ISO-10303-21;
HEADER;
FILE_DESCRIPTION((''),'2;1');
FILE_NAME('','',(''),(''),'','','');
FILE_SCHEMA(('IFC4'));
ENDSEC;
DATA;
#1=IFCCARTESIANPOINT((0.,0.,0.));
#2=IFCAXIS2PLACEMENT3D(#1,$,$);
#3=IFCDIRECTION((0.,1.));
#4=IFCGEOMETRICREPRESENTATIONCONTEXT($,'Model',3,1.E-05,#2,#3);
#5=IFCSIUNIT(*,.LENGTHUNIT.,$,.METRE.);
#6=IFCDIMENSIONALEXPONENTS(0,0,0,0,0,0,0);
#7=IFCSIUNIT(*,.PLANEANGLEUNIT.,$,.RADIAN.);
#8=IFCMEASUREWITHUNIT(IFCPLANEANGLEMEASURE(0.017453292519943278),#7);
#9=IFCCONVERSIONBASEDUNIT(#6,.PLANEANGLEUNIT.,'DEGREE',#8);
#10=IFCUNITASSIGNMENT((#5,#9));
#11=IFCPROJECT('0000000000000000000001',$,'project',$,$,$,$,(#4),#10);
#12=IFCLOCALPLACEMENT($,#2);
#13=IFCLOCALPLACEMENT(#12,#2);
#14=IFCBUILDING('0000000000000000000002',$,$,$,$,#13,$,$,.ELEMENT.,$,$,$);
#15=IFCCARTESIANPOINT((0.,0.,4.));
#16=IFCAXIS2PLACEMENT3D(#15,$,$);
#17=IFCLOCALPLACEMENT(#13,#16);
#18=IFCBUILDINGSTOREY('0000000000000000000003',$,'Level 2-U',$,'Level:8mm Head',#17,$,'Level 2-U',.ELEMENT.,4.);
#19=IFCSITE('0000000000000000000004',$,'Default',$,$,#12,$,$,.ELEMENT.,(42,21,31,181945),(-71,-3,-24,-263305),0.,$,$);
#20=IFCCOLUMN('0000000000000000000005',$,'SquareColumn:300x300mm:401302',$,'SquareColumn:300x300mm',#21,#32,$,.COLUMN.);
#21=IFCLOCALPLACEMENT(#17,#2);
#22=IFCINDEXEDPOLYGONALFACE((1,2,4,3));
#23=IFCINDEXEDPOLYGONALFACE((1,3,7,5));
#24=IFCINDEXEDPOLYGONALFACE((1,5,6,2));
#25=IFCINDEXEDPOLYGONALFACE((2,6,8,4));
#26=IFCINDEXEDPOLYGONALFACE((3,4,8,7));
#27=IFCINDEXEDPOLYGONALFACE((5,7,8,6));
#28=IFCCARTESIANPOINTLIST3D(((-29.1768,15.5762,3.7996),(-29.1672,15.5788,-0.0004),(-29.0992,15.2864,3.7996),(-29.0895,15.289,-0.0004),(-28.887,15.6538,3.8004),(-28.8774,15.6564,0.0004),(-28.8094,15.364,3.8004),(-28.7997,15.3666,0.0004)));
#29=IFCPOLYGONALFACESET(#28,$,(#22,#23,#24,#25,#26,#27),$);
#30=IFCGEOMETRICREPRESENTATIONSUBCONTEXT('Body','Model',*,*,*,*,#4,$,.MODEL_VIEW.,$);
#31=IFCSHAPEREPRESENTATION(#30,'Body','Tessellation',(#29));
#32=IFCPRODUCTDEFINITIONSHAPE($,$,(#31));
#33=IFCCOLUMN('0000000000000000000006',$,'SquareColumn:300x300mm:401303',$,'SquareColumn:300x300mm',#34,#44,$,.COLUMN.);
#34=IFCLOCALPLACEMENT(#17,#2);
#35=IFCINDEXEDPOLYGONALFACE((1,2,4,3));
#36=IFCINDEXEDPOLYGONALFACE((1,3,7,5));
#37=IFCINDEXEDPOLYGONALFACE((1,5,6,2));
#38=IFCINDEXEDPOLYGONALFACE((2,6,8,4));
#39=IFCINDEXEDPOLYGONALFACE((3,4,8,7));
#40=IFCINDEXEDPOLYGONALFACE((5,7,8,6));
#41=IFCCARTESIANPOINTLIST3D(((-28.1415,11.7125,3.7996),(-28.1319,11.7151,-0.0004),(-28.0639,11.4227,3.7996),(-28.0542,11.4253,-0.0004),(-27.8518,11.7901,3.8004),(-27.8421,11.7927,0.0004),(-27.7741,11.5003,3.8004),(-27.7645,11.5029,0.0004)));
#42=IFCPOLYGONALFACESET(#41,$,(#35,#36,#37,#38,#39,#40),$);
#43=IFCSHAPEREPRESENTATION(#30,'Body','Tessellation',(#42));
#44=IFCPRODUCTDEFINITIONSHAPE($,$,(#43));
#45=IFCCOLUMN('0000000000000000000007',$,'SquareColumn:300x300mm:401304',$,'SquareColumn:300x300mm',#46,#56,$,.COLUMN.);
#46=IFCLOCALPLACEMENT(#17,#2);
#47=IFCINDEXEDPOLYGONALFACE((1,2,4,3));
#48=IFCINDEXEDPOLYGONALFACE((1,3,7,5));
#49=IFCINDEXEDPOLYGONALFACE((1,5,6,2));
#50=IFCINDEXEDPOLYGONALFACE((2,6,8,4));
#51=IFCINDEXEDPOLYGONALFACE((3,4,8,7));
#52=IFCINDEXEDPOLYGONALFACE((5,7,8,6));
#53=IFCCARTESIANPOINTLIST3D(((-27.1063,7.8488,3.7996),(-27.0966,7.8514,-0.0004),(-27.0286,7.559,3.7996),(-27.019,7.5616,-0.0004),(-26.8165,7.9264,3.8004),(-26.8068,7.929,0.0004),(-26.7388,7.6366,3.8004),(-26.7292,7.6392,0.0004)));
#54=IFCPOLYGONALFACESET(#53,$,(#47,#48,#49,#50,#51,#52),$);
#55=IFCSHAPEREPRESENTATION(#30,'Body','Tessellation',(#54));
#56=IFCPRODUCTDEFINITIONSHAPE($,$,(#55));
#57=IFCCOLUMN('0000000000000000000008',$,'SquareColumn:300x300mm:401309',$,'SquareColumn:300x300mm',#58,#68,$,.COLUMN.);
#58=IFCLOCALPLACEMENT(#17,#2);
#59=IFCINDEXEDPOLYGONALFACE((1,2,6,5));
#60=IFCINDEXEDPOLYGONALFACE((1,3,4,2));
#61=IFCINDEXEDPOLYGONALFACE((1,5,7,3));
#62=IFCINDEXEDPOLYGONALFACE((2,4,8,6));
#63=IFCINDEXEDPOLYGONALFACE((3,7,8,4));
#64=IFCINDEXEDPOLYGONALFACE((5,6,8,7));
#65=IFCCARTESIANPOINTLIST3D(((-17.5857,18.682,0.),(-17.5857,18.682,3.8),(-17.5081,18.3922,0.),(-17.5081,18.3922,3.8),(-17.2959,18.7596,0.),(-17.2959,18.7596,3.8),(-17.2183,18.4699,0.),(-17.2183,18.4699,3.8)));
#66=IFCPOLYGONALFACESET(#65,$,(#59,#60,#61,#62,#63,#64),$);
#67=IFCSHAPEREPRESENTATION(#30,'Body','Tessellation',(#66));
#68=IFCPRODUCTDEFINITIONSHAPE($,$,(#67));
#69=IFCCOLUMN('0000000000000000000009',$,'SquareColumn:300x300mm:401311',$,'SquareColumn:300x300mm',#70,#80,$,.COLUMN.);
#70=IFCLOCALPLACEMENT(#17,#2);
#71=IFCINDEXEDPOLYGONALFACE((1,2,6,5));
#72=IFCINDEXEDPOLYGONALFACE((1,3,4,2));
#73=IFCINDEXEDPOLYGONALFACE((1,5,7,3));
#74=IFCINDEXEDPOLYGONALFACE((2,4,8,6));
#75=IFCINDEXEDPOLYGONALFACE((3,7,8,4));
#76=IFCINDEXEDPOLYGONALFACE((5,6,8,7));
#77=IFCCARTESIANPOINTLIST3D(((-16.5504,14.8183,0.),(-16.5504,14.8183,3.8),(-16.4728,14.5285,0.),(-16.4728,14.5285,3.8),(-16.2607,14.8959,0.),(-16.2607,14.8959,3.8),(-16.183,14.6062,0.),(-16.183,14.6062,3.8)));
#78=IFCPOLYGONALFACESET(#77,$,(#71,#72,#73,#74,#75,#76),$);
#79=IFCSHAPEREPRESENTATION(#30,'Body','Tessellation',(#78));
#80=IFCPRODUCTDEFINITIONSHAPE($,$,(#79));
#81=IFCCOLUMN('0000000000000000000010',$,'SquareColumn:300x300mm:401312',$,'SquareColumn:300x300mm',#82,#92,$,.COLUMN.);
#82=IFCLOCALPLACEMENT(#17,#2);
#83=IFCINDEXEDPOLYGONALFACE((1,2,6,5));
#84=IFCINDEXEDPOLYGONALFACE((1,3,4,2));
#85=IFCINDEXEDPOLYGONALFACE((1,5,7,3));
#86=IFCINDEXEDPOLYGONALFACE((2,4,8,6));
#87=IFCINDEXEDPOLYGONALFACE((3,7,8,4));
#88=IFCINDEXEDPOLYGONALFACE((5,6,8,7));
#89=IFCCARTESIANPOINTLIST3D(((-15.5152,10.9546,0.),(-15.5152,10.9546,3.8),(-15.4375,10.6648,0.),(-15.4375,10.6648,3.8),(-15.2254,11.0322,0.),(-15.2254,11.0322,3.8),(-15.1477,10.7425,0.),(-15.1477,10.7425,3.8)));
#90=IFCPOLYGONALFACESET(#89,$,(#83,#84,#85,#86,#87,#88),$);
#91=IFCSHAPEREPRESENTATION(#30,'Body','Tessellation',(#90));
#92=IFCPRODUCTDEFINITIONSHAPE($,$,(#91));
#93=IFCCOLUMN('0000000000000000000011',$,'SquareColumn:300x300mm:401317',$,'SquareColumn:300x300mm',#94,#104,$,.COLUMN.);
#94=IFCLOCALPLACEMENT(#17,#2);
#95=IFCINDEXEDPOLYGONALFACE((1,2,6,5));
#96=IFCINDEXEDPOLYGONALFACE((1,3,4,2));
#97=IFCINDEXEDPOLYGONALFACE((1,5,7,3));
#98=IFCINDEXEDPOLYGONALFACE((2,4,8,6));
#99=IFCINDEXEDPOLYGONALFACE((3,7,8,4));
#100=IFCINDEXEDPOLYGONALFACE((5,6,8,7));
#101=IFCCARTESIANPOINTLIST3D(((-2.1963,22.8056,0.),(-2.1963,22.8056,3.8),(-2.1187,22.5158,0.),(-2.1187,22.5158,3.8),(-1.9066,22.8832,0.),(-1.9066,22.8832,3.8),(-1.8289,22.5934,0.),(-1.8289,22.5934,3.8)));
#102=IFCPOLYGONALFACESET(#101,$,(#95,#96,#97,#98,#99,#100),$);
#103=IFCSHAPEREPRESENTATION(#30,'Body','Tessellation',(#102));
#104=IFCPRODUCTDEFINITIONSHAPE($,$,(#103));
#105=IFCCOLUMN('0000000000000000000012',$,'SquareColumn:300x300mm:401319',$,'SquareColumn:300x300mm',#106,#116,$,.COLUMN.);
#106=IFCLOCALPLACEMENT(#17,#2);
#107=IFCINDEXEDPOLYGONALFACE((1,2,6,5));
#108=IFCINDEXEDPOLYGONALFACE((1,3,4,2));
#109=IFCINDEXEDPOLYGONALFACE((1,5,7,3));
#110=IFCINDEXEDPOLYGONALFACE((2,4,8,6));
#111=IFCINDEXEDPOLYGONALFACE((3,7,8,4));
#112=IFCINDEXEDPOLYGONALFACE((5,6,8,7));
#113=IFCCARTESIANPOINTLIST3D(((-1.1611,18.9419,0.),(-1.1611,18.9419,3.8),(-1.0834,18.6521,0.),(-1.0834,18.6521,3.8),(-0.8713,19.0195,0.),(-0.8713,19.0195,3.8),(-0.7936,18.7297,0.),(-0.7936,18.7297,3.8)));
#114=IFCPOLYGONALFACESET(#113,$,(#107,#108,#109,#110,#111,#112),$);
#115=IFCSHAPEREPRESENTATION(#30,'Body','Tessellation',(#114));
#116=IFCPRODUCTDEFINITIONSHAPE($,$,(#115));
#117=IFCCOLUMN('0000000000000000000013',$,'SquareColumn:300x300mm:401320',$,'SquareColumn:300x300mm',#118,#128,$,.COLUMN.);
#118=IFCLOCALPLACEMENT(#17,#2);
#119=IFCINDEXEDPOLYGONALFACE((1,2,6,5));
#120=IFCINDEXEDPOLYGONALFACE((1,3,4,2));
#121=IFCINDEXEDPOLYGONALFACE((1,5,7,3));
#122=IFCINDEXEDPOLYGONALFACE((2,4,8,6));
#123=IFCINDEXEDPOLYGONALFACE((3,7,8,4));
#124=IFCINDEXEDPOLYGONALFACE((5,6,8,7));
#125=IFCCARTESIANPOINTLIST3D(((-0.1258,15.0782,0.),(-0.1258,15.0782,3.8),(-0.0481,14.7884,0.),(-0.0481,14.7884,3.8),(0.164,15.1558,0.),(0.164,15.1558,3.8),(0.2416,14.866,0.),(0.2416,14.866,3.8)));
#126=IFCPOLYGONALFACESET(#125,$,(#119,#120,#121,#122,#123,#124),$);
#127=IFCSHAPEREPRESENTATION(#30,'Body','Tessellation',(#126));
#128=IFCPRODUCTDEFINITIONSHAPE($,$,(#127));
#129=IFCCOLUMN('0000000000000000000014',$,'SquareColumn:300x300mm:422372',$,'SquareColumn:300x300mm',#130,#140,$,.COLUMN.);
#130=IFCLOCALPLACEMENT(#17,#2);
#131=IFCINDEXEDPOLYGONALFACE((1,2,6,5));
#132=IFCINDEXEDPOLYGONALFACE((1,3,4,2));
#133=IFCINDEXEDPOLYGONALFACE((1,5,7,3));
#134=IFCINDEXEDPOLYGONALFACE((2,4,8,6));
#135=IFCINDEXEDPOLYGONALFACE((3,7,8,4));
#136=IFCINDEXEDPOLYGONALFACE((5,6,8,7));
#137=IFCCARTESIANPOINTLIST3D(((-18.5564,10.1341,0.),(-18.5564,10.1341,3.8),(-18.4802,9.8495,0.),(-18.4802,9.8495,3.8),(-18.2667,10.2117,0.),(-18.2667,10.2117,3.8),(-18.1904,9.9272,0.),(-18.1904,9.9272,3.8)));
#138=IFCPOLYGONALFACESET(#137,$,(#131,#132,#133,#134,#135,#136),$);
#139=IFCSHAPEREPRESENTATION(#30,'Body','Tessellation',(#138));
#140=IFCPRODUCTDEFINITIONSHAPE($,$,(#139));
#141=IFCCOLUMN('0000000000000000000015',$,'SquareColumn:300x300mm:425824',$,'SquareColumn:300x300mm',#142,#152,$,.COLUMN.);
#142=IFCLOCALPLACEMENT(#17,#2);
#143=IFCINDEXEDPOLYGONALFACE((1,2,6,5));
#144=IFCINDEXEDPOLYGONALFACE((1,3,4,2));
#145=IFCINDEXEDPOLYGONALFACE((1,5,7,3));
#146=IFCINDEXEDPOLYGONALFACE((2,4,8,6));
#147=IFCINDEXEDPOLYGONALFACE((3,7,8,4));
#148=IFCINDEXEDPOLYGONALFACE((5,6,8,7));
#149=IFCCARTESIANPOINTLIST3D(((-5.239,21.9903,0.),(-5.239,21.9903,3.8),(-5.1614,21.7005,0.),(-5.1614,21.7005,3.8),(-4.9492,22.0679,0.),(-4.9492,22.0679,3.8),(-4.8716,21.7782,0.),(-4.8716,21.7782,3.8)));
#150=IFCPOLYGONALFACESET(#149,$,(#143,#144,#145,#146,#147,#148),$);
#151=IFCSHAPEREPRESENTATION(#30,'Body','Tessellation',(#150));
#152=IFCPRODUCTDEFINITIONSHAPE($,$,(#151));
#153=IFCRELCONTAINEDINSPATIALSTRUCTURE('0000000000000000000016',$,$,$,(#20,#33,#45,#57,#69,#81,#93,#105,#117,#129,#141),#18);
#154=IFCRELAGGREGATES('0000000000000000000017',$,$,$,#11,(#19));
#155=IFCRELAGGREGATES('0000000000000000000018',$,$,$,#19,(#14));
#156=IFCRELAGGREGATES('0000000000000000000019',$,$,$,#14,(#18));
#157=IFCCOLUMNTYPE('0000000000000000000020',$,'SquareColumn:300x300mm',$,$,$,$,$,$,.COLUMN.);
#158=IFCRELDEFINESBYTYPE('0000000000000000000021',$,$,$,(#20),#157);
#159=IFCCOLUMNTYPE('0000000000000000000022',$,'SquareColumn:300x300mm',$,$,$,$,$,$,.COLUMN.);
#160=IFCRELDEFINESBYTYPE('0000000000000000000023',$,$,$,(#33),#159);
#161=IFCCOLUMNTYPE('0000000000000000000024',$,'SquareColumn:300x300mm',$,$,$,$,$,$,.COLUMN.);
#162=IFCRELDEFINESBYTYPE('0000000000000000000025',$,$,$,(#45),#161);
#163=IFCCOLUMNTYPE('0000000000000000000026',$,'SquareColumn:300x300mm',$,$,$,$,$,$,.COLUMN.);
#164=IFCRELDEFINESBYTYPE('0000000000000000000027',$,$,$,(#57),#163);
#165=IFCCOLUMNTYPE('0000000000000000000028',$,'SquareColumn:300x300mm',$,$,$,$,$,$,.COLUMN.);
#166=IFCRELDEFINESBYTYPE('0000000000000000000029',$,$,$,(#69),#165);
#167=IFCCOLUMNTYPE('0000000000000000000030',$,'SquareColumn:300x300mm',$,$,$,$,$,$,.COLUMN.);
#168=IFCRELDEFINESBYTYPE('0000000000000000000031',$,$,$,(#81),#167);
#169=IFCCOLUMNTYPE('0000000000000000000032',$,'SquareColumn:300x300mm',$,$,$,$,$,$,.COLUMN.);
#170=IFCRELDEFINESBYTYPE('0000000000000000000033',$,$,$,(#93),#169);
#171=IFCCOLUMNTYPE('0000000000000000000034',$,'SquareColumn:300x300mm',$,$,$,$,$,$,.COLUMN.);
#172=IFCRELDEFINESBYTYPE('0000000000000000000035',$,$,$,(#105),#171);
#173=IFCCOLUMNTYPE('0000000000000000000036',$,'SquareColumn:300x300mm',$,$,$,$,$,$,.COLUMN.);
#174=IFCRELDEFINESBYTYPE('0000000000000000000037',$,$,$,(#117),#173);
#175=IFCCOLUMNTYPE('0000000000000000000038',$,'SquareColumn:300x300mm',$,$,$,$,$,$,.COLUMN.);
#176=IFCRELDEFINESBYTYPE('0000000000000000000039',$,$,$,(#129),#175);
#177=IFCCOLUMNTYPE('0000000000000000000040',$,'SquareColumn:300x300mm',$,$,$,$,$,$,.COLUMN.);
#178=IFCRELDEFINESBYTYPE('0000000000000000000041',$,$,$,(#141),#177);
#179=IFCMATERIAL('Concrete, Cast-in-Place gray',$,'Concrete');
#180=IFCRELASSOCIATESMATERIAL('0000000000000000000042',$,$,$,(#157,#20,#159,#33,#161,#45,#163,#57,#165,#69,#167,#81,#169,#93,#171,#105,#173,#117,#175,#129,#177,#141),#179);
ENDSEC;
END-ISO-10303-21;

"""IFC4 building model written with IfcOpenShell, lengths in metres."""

from ifc_helpers import new_model, entity, si_unit, converted_unit, direction, frame, origin, place, context, subcontext, project, spatial, indexed_curve, outline, extrude, source, transform, mapped, material, type_object, type_shapes, element, save


model = new_model("IFC4")

# Units and contexts
model_context = context("Model", 3, precision=1e-05, world=origin(), true_north=direction((0.0, 1.0)))
body_context = subcontext(model_context, "Body", "Model", "MODEL_VIEW")
ifc_project = project(units=[si_unit("LENGTHUNIT", "METRE"), converted_unit("PLANEANGLEUNIT", "DEGREE", entity("IfcPlaneAngleMeasure", 0.017453292519943278), si_unit("PLANEANGLEUNIT", "RADIAN"), dimensions=[0, 0, 0, 0, 0, 0, 0])], contexts=[model_context])

# Site, building, storey
site_placement = place(None, origin())
site = spatial("IfcSite", under=ifc_project, at=site_placement, Name="Default", CompositionType="ELEMENT", RefLatitude=(42, 21, 31, 181945), RefLongitude=(-71, -3, -24, -263305), RefElevation=0.0)
building_placement = place(site_placement, origin())
building = spatial("IfcBuilding", under=site, at=building_placement, CompositionType="ELEMENT")
storey_placement = place(building_placement, frame((0.0, 0.0, 4.0)))
storey = spatial("IfcBuildingStorey", under=building, at=storey_placement, Name="Level 2-U", ObjectType="Level:8mm Head", LongName="Level 2-U", CompositionType="ELEMENT", Elevation=4.0)

# Columns
ifc_material_1 = material(Name="Concrete, Cast-in-Place gray", Category="Concrete")
column_type_1 = type_object("IfcColumnType", Name="SquareColumn:300x300mm", PredefinedType="COLUMN", material=ifc_material_1)
shared_shape_1 = source(origin(), body_context, "Body", "SweptSolid", [
    extrude(outline(indexed_curve([(-0.15, -0.15), (0.15, -0.15), (0.15, 0.15), (-0.15, 0.15), (-0.15, -0.15)], self_intersect=False)), frame((-28.9835, 15.4727, 4.0), z_axis=(-0.002542, -0.000681, 0.999997), x_axis=(-0.258819, 0.965926, 0.0)), (0.0, 0.0, 1.0), 3.8),
])
type_shapes(column_type_1, [shared_shape_1])
column_1_placement = place(storey_placement, frame((0.0, 0.0, -4.0)))
element("IfcColumn", 1, at=column_1_placement, inside=storey, type_object=column_type_1, material=ifc_material_1, Name="SquareColumn:300x300mm:401302", ObjectType="SquareColumn:300x300mm", PredefinedType="COLUMN", context=body_context, shape_type="MappedRepresentation", body=[
    mapped(shared_shape_1, transform((0.0, 0.0, 0.0), scale=1.0)),
])
column_type_2 = type_object("IfcColumnType", Name="SquareColumn:300x300mm", PredefinedType="COLUMN", material=ifc_material_1)
shared_shape_2 = source(origin(), body_context, "Body", "SweptSolid", [
    extrude(outline(indexed_curve([(-0.15, -0.15), (0.15, -0.15), (0.15, 0.15), (-0.15, 0.15), (-0.15, -0.15)], self_intersect=False)), frame((-27.9482, 11.609, 4.0), z_axis=(-0.002542, -0.000681, 0.999997), x_axis=(-0.258819, 0.965926, 0.0)), (0.0, 0.0, 1.0), 3.8),
])
type_shapes(column_type_2, [shared_shape_2])
column_2_placement = place(storey_placement, frame((0.0, 0.0, -4.0)))
element("IfcColumn", 2, at=column_2_placement, inside=storey, type_object=column_type_2, material=ifc_material_1, Name="SquareColumn:300x300mm:401303", ObjectType="SquareColumn:300x300mm", PredefinedType="COLUMN", context=body_context, shape_type="MappedRepresentation", body=[
    mapped(shared_shape_2, transform((0.0, 0.0, 0.0), scale=1.0)),
])
column_type_3 = type_object("IfcColumnType", Name="SquareColumn:300x300mm", PredefinedType="COLUMN", material=ifc_material_1)
shared_shape_3 = source(origin(), body_context, "Body", "SweptSolid", [
    extrude(outline(indexed_curve([(-0.15, -0.15), (0.15, -0.15), (0.15, 0.15), (-0.15, 0.15), (-0.15, -0.15)], self_intersect=False)), frame((-26.9129, 7.7453, 4.0), z_axis=(-0.002542, -0.000681, 0.999997), x_axis=(-0.258819, 0.965926, 0.0)), (0.0, 0.0, 1.0), 3.8),
])
type_shapes(column_type_3, [shared_shape_3])
column_3_placement = place(storey_placement, frame((0.0, 0.0, -4.0)))
element("IfcColumn", 3, at=column_3_placement, inside=storey, type_object=column_type_3, material=ifc_material_1, Name="SquareColumn:300x300mm:401304", ObjectType="SquareColumn:300x300mm", PredefinedType="COLUMN", context=body_context, shape_type="MappedRepresentation", body=[
    mapped(shared_shape_3, transform((0.0, 0.0, 0.0), scale=1.0)),
])
column_type_4 = type_object("IfcColumnType", Name="SquareColumn:300x300mm", PredefinedType="COLUMN", material=ifc_material_1)
shared_shape_4 = source(origin(), body_context, "Body", "SweptSolid", [
    extrude(outline(indexed_curve([(-0.15, -0.15), (0.15, -0.15), (0.15, 0.15), (-0.15, 0.15), (-0.15, -0.15)], self_intersect=False)), frame((-17.402, 18.5759, 4.0), z_axis=(0.0, 0.0, 1.0), x_axis=(-0.258819, 0.965926, 0.0)), (0.0, 0.0, 1.0), 3.8),
])
type_shapes(column_type_4, [shared_shape_4])
column_4_placement = place(storey_placement, frame((0.0, 0.0, -4.0)))
element("IfcColumn", 4, at=column_4_placement, inside=storey, type_object=column_type_4, material=ifc_material_1, Name="SquareColumn:300x300mm:401309", ObjectType="SquareColumn:300x300mm", PredefinedType="COLUMN", context=body_context, shape_type="MappedRepresentation", body=[
    mapped(shared_shape_4, transform((0.0, 0.0, 0.0), scale=1.0)),
])
column_type_5 = type_object("IfcColumnType", Name="SquareColumn:300x300mm", PredefinedType="COLUMN", material=ifc_material_1)
shared_shape_5 = source(origin(), body_context, "Body", "SweptSolid", [
    extrude(outline(indexed_curve([(-0.15, -0.15), (0.15, -0.15), (0.15, 0.15), (-0.15, 0.15), (-0.15, -0.15)], self_intersect=False)), frame((-16.3667, 14.7122, 4.0), z_axis=(0.0, 0.0, 1.0), x_axis=(-0.258819, 0.965926, 0.0)), (0.0, 0.0, 1.0), 3.8),
])
type_shapes(column_type_5, [shared_shape_5])
column_5_placement = place(storey_placement, frame((0.0, 0.0, -4.0)))
element("IfcColumn", 5, at=column_5_placement, inside=storey, type_object=column_type_5, material=ifc_material_1, Name="SquareColumn:300x300mm:401311", ObjectType="SquareColumn:300x300mm", PredefinedType="COLUMN", context=body_context, shape_type="MappedRepresentation", body=[
    mapped(shared_shape_5, transform((0.0, 0.0, 0.0), scale=1.0)),
])
column_type_6 = type_object("IfcColumnType", Name="SquareColumn:300x300mm", PredefinedType="COLUMN", material=ifc_material_1)
shared_shape_6 = source(origin(), body_context, "Body", "SweptSolid", [
    extrude(outline(indexed_curve([(-0.15, -0.15), (0.15, -0.15), (0.15, 0.15), (-0.15, 0.15), (-0.15, -0.15)], self_intersect=False)), frame((-15.3314, 10.8485, 4.0), z_axis=(0.0, 0.0, 1.0), x_axis=(-0.258819, 0.965926, 0.0)), (0.0, 0.0, 1.0), 3.8),
])
type_shapes(column_type_6, [shared_shape_6])
column_6_placement = place(storey_placement, frame((0.0, 0.0, -4.0)))
element("IfcColumn", 6, at=column_6_placement, inside=storey, type_object=column_type_6, material=ifc_material_1, Name="SquareColumn:300x300mm:401312", ObjectType="SquareColumn:300x300mm", PredefinedType="COLUMN", context=body_context, shape_type="MappedRepresentation", body=[
    mapped(shared_shape_6, transform((0.0, 0.0, 0.0), scale=1.0)),
])
column_type_7 = type_object("IfcColumnType", Name="SquareColumn:300x300mm", PredefinedType="COLUMN", material=ifc_material_1)
shared_shape_7 = source(origin(), body_context, "Body", "SweptSolid", [
    extrude(outline(indexed_curve([(-0.15, -0.15), (0.15, -0.15), (0.15, 0.15), (-0.15, 0.15), (-0.15, -0.15)], self_intersect=False)), frame((-2.0126, 22.6995, 4.0), z_axis=(0.0, 0.0, 1.0), x_axis=(-0.258819, 0.965926, 0.0)), (0.0, 0.0, 1.0), 3.8),
])
type_shapes(column_type_7, [shared_shape_7])
column_7_placement = place(storey_placement, frame((0.0, 0.0, -4.0)))
element("IfcColumn", 7, at=column_7_placement, inside=storey, type_object=column_type_7, material=ifc_material_1, Name="SquareColumn:300x300mm:401317", ObjectType="SquareColumn:300x300mm", PredefinedType="COLUMN", context=body_context, shape_type="MappedRepresentation", body=[
    mapped(shared_shape_7, transform((0.0, 0.0, 0.0), scale=1.0)),
])
column_type_8 = type_object("IfcColumnType", Name="SquareColumn:300x300mm", PredefinedType="COLUMN", material=ifc_material_1)
shared_shape_8 = source(origin(), body_context, "Body", "SweptSolid", [
    extrude(outline(indexed_curve([(-0.15, -0.15), (0.15, -0.15), (0.15, 0.15), (-0.15, 0.15), (-0.15, -0.15)], self_intersect=False)), frame((-0.9774, 18.8358, 4.0), z_axis=(0.0, 0.0, 1.0), x_axis=(-0.258819, 0.965926, 0.0)), (0.0, 0.0, 1.0), 3.8),
])
type_shapes(column_type_8, [shared_shape_8])
column_8_placement = place(storey_placement, frame((0.0, 0.0, -4.0)))
element("IfcColumn", 8, at=column_8_placement, inside=storey, type_object=column_type_8, material=ifc_material_1, Name="SquareColumn:300x300mm:401319", ObjectType="SquareColumn:300x300mm", PredefinedType="COLUMN", context=body_context, shape_type="MappedRepresentation", body=[
    mapped(shared_shape_8, transform((0.0, 0.0, 0.0), scale=1.0)),
])
column_type_9 = type_object("IfcColumnType", Name="SquareColumn:300x300mm", PredefinedType="COLUMN", material=ifc_material_1)
shared_shape_9 = source(origin(), body_context, "Body", "SweptSolid", [
    extrude(outline(indexed_curve([(-0.15, -0.15), (0.15, -0.15), (0.15, 0.15), (-0.15, 0.15), (-0.15, -0.15)], self_intersect=False)), frame((0.0579, 14.9721, 4.0), z_axis=(0.0, 0.0, 1.0), x_axis=(-0.258819, 0.965926, 0.0)), (0.0, 0.0, 1.0), 3.8),
])
type_shapes(column_type_9, [shared_shape_9])
column_9_placement = place(storey_placement, frame((0.0, 0.0, -4.0)))
element("IfcColumn", 9, at=column_9_placement, inside=storey, type_object=column_type_9, material=ifc_material_1, Name="SquareColumn:300x300mm:401320", ObjectType="SquareColumn:300x300mm", PredefinedType="COLUMN", context=body_context, shape_type="MappedRepresentation", body=[
    mapped(shared_shape_9, transform((0.0, 0.0, 0.0), scale=1.0)),
])
column_type_10 = type_object("IfcColumnType", Name="SquareColumn:300x300mm", PredefinedType="COLUMN", material=ifc_material_1)
shared_shape_10 = source(origin(), body_context, "Body", "SweptSolid", [
    extrude(outline(indexed_curve([(-0.1473, -0.15), (0.1473, -0.15), (0.1473, 0.15), (-0.1473, 0.15), (-0.1473, -0.15)], self_intersect=False)), frame((-18.3734, 10.0306, 4.0), z_axis=(0.0, 0.0, 1.0), x_axis=(-0.258819, 0.965926, 0.0)), (0.0, 0.0, 1.0), 3.8),
])
type_shapes(column_type_10, [shared_shape_10])
column_10_placement = place(storey_placement, frame((0.0, 0.0, -4.0)))
element("IfcColumn", 10, at=column_10_placement, inside=storey, type_object=column_type_10, material=ifc_material_1, Name="SquareColumn:300x300mm:422372", ObjectType="SquareColumn:300x300mm", PredefinedType="COLUMN", context=body_context, shape_type="MappedRepresentation", body=[
    mapped(shared_shape_10, transform((0.0, 0.0, 0.0), scale=1.0)),
])
column_type_11 = type_object("IfcColumnType", Name="SquareColumn:300x300mm", PredefinedType="COLUMN", material=ifc_material_1)
shared_shape_11 = source(origin(), body_context, "Body", "SweptSolid", [
    extrude(outline(indexed_curve([(-0.15, -0.15), (0.15, -0.15), (0.15, 0.15), (-0.15, 0.15), (-0.15, -0.15)], self_intersect=False)), frame((-5.0553, 21.8842, 4.0), z_axis=(0.0, 0.0, 1.0), x_axis=(-0.258819, 0.965926, 0.0)), (0.0, 0.0, 1.0), 3.8),
])
type_shapes(column_type_11, [shared_shape_11])
column_11_placement = place(storey_placement, frame((0.0, 0.0, -4.0)))
element("IfcColumn", 11, at=column_11_placement, inside=storey, type_object=column_type_11, material=ifc_material_1, Name="SquareColumn:300x300mm:425824", ObjectType="SquareColumn:300x300mm", PredefinedType="COLUMN", context=body_context, shape_type="MappedRepresentation", body=[
    mapped(shared_shape_11, transform((0.0, 0.0, 0.0), scale=1.0)),
])

save(model, "model.ifc")
